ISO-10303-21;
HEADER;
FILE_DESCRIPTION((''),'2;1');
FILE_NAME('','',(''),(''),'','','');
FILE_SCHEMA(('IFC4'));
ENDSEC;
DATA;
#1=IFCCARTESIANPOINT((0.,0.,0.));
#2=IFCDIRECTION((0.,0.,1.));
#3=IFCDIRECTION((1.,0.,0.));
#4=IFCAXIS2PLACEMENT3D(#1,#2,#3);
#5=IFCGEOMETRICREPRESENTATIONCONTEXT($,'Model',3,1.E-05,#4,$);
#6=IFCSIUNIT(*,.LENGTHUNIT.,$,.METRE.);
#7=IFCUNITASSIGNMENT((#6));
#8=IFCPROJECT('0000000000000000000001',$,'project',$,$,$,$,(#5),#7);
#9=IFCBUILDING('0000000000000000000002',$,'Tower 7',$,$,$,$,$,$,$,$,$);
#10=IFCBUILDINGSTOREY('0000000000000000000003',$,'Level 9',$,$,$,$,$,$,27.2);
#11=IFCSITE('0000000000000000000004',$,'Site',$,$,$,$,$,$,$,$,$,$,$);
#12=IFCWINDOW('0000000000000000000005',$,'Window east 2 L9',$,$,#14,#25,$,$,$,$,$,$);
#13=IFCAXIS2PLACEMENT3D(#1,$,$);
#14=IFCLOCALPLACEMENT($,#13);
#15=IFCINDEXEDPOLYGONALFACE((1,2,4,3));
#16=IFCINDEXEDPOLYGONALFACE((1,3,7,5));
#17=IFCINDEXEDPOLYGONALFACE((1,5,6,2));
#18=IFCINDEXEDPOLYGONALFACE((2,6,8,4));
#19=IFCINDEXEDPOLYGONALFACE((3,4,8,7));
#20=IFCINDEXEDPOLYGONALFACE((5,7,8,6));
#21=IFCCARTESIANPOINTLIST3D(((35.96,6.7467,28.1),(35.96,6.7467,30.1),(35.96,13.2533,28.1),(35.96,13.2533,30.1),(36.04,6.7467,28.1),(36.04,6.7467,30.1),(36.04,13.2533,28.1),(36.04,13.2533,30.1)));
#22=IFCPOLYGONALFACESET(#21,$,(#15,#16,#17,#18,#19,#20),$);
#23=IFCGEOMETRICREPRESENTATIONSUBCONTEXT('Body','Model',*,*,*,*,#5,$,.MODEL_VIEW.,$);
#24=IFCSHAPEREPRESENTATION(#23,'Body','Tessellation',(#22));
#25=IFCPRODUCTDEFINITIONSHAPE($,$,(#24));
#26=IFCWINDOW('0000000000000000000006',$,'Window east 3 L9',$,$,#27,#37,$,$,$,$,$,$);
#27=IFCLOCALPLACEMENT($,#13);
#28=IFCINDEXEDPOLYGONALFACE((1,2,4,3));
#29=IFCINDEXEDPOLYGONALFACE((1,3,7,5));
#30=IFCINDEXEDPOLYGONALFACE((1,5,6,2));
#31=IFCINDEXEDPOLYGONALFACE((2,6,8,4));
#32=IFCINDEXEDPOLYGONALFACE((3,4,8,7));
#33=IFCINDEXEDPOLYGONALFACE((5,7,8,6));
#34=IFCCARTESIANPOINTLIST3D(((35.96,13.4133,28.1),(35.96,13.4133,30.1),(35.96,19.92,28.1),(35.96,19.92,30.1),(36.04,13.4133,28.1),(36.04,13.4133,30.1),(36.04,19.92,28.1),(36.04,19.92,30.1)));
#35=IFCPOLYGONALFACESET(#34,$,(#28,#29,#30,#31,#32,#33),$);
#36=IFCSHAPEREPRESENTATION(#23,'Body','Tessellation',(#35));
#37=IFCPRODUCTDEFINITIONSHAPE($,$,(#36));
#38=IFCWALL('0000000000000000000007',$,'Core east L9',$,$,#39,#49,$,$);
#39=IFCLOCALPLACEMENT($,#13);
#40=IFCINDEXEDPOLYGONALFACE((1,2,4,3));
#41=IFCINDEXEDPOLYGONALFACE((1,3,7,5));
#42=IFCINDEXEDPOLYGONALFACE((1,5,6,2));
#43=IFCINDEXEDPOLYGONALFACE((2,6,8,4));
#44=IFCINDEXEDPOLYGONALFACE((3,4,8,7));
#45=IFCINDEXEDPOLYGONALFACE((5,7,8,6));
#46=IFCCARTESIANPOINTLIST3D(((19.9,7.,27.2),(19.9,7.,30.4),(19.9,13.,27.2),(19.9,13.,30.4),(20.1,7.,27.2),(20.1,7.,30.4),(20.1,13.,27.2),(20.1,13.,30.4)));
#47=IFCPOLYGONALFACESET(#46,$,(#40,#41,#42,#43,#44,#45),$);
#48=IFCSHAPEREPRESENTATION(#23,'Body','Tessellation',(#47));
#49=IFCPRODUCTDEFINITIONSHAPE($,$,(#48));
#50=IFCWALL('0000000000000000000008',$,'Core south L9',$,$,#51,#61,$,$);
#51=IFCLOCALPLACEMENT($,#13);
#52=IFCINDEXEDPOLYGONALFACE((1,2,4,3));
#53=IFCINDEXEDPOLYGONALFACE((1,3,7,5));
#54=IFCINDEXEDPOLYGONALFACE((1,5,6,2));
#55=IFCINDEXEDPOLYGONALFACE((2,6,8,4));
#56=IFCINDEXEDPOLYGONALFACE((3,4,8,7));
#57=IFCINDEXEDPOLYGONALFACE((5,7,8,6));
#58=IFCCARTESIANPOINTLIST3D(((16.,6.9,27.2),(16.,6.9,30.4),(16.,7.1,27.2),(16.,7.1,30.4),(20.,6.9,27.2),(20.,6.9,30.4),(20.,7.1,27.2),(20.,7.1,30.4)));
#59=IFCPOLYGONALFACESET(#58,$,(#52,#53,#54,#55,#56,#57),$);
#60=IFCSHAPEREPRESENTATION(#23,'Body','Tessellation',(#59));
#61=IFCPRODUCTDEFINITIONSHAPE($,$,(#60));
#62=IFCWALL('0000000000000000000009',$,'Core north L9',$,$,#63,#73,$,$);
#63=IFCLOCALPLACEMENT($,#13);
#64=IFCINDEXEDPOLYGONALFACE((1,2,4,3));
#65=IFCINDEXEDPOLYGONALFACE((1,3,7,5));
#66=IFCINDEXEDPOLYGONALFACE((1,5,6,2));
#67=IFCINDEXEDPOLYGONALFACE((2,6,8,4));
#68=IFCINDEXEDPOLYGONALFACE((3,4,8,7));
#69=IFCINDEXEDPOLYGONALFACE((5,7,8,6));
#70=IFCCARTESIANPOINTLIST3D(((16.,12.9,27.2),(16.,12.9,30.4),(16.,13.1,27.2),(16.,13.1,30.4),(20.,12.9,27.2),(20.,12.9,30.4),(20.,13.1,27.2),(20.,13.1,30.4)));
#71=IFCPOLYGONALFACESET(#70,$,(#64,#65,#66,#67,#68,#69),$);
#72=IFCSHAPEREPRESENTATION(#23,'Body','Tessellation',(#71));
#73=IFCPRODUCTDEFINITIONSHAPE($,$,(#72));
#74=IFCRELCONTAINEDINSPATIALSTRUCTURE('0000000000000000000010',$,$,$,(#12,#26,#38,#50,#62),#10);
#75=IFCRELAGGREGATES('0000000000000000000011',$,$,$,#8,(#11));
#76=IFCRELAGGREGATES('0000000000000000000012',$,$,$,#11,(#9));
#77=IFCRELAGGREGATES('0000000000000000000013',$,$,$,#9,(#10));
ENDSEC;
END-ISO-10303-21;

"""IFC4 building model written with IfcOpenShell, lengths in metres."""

from ifc_helpers import new_model, si_unit, frame, origin, origin_with_axes, origin_2d, place, context, subcontext, project, spatial, rectangle, extrude, element, save


model = new_model("IFC4")

# Units and contexts
model_context = context("Model", 3, precision=1e-05, world=origin_with_axes())
body_context = subcontext(model_context, "Body", "Model", "MODEL_VIEW")
ifc_project = project(units=[si_unit("LENGTHUNIT", "METRE")], contexts=[model_context])

# Site, building, storey
site = spatial("IfcSite", under=ifc_project, Name="Site")
building = spatial("IfcBuilding", under=site, Name="Tower 7")
storey = spatial("IfcBuildingStorey", under=building, Name="Level 9", Elevation=27.2)

# Windows
for number, where, z_axis, x_axis, name in (
    (1, (36.0, 10.0, 28.1), (0.0, 0.0, 1.0), (1.0, 0.0, 0.0), "Window east 2 L9"),
):
    element("IfcWindow", number, at=place(None, frame(where, z_axis=z_axis, x_axis=x_axis)), inside=storey, Name=name, context=body_context, shape_type="SweptSolid", body=[
        extrude(rectangle(XDim=0.08, YDim=6.5067, at=origin_2d()), origin(), (0.0, 0.0, 1.0), 2.0),
    ])
window_placement = place(None, frame((36.0, 16.6667, 28.1), z_axis=(0.0, 0.0, 1.0), x_axis=(1.0, 0.0, 0.0)))
element("IfcWindow", 2, at=window_placement, inside=storey, Name="Window east 3 L9", context=body_context, shape_type="SweptSolid", body=[
    extrude(rectangle(XDim=0.08, YDim=6.5067, at=origin_2d()), origin(), (0.0, 0.0, 1.0), 2.0),
])

# Walls
wall_1_placement = place(None, frame((20.0, 10.0, 27.2), z_axis=(0.0, 0.0, 1.0), x_axis=(1.0, 0.0, 0.0)))
element("IfcWall", 3, at=wall_1_placement, inside=storey, Name="Core east L9", context=body_context, shape_type="SweptSolid", body=[
    extrude(rectangle(XDim=0.2, YDim=6.0, at=origin_2d()), origin(), (0.0, 0.0, 1.0), 3.2),
])
for number, where, z_axis, x_axis, name in (
    (4, (18.0, 7.0, 27.2), (0.0, 0.0, 1.0), (1.0, 0.0, 0.0), "Core south L9"),
    (5, (18.0, 13.0, 27.2), (0.0, 0.0, 1.0), (1.0, 0.0, 0.0), "Core north L9"),
):
    element("IfcWall", number, at=place(None, frame(where, z_axis=z_axis, x_axis=x_axis)), inside=storey, Name=name, context=body_context, shape_type="SweptSolid", body=[
        extrude(rectangle(XDim=4.0, YDim=0.2, at=origin_2d()), origin(), (0.0, 0.0, 1.0), 3.2),
    ])

save(model, "model.ifc")
